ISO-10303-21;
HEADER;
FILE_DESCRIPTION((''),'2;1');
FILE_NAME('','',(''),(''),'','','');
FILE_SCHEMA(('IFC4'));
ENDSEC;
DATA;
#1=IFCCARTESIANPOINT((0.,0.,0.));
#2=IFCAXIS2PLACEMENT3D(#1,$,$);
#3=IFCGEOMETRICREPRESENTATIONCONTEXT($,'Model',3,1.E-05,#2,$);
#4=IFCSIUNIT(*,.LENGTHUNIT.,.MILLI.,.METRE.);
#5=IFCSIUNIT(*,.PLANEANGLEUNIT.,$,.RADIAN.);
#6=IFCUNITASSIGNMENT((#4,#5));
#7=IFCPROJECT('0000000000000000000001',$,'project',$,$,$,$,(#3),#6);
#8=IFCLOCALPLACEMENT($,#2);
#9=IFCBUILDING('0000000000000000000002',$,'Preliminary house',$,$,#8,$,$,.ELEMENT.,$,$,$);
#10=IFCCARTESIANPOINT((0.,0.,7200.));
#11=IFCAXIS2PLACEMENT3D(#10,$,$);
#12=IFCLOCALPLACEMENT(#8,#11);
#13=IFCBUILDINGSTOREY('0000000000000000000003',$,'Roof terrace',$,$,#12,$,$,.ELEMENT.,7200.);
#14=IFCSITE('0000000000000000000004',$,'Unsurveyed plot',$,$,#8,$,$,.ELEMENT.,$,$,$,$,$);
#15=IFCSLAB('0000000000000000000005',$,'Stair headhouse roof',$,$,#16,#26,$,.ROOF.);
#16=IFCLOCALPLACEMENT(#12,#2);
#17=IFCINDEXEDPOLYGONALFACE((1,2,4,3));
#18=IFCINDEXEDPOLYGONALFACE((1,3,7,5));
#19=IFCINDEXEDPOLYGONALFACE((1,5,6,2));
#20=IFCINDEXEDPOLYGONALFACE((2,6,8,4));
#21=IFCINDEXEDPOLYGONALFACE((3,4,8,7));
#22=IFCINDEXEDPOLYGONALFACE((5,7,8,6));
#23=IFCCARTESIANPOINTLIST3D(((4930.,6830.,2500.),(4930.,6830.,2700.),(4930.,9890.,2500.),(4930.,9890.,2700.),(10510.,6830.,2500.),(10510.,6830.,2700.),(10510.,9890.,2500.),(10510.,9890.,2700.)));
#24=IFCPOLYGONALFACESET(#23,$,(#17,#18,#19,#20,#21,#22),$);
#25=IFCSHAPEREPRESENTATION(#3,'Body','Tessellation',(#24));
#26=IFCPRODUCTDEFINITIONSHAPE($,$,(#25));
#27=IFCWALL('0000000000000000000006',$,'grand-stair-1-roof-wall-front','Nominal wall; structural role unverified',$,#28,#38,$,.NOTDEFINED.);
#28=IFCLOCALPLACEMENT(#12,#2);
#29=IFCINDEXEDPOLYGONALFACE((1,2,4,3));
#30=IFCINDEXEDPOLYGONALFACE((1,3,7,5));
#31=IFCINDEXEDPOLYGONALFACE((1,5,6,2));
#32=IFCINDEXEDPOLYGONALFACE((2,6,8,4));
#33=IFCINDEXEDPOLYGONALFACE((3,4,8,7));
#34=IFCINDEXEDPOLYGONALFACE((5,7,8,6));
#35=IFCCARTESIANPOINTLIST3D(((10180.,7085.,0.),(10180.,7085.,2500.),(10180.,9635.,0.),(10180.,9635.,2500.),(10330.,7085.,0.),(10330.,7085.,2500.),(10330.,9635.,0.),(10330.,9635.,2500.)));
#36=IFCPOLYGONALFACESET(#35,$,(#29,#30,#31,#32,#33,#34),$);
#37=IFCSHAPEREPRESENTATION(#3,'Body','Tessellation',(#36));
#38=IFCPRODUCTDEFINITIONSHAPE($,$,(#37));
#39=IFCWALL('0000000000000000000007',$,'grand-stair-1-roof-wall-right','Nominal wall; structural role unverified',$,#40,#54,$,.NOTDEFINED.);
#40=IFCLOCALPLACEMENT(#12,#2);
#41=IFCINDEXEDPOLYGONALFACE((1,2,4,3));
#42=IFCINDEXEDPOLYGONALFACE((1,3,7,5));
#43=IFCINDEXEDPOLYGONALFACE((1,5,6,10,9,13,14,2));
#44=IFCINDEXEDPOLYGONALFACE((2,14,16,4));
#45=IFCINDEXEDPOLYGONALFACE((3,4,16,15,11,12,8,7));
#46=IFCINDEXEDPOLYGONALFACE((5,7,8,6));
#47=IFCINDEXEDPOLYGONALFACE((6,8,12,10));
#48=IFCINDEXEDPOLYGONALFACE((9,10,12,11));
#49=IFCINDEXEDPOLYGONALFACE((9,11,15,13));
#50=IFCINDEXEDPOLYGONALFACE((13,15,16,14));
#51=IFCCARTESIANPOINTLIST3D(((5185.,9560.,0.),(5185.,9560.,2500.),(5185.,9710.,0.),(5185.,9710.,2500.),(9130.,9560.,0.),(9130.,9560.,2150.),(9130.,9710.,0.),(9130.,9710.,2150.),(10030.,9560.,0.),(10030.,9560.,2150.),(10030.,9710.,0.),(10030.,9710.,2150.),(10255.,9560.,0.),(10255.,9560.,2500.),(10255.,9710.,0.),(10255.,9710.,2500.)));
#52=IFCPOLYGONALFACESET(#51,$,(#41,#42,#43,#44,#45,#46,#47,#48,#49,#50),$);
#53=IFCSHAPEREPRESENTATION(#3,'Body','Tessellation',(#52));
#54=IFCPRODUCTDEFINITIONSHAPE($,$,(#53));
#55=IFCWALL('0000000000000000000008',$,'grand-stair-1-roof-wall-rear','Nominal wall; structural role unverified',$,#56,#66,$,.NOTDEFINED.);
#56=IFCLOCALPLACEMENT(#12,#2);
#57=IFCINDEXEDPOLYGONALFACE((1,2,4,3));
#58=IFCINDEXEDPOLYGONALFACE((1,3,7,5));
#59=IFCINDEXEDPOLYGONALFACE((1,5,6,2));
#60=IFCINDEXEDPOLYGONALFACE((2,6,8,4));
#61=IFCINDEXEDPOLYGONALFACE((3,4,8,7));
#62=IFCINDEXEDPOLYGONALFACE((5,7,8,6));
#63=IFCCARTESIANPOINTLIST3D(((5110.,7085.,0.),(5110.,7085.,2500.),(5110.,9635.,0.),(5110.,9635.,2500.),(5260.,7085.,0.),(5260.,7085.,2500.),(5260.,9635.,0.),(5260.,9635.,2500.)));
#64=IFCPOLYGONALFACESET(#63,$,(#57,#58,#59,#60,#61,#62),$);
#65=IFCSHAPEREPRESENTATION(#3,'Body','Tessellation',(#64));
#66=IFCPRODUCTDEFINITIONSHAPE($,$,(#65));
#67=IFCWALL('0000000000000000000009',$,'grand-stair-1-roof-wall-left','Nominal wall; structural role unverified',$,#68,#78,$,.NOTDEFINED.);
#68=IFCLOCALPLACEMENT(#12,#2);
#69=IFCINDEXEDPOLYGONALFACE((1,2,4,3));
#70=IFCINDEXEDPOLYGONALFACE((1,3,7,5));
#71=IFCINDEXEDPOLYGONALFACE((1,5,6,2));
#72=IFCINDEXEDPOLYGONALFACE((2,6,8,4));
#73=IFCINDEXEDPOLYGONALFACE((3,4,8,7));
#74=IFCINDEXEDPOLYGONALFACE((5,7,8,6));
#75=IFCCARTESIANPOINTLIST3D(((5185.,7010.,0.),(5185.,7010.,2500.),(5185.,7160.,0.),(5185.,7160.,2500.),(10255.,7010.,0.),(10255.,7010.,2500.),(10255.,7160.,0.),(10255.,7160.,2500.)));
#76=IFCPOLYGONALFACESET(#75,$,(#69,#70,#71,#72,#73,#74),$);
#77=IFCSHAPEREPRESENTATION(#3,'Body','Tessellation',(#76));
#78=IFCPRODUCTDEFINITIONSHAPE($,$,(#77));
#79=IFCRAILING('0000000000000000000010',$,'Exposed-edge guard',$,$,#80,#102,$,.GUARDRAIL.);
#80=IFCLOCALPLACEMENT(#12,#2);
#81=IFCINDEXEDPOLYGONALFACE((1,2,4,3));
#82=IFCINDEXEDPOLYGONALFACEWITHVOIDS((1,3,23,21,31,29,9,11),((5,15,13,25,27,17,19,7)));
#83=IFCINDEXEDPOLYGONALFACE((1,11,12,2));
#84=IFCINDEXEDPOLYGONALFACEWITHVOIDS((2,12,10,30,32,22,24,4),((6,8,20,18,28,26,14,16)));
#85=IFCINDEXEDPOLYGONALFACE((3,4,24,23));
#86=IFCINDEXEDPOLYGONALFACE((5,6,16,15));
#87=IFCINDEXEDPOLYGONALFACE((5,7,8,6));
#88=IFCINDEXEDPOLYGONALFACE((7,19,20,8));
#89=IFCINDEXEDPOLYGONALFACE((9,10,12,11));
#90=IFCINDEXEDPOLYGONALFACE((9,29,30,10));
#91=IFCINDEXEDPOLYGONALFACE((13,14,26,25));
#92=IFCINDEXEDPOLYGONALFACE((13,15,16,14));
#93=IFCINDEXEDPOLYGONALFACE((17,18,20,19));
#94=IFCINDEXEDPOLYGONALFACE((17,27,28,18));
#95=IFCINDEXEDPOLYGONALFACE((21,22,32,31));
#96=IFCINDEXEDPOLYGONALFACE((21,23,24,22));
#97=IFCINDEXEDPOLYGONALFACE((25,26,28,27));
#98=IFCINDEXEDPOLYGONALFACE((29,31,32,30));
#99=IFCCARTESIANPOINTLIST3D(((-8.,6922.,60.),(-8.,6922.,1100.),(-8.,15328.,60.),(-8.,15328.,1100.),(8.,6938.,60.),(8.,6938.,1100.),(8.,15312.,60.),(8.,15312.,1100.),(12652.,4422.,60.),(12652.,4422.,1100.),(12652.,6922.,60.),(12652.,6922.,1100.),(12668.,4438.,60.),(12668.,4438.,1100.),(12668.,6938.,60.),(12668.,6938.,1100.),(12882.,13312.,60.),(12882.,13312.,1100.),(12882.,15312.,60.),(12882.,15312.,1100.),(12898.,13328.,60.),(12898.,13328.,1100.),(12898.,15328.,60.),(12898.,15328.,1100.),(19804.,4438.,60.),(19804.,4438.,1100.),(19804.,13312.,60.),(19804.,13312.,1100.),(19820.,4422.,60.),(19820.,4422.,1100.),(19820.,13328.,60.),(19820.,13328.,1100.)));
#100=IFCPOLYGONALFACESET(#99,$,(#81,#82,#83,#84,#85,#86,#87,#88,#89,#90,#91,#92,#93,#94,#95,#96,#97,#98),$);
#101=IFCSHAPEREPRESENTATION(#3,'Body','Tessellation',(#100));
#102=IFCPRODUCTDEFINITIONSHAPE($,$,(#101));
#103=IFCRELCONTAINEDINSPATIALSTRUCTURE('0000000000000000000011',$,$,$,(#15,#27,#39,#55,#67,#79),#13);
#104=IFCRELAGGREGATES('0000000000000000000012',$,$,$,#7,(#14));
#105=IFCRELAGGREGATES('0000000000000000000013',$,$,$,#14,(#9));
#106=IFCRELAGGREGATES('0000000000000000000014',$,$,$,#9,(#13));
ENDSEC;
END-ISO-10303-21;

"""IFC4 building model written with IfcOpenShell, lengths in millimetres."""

from ifc_helpers import new_model, si_unit, frame, origin, place, context, project, spatial, polyline, outline, extrude, element, save


model = new_model("IFC4")

# Units and contexts
model_context = context("Model", 3, precision=1e-05, world=origin())
ifc_project = project(units=[si_unit("LENGTHUNIT", "METRE", prefix="MILLI"), si_unit("PLANEANGLEUNIT", "RADIAN")], contexts=[model_context])

# Site, building, storey
placement_1 = place(None, origin())
site = spatial("IfcSite", under=ifc_project, at=placement_1, Name="Unsurveyed plot", CompositionType="ELEMENT")
building = spatial("IfcBuilding", under=site, at=placement_1, Name="Preliminary house", CompositionType="ELEMENT")
placement_2 = place(placement_1, frame((0.0, 0.0, 7200.0)))
storey = spatial("IfcBuildingStorey", under=building, at=placement_2, Name="Roof terrace", CompositionType="ELEMENT", Elevation=7200.0)

# Slab
element("IfcSlab", 1, at=placement_2, inside=storey, Name="Stair headhouse roof", PredefinedType="ROOF", context=model_context, shape_type="SweptSolid", body=[
    extrude(outline(polyline([(10510.0, 6830.0), (4930.0, 6830.0), (4930.0, 9890.0), (10510.0, 9890.0), (10510.0, 6830.0)])), frame((0.0, 0.0, 2500.0)), (0.0, 0.0, 1.0), 200.0),
])

# Wall
element("IfcWall", 2, at=placement_2, inside=storey, Name="grand-stair-1-roof-wall-front", Description="Nominal wall; structural role unverified", PredefinedType="NOTDEFINED", context=model_context, shape_type="SweptSolid", body=[
    extrude(outline(polyline([(10180.0, 9635.0), (10330.0, 9635.0), (10330.0, 7085.0), (10180.0, 7085.0), (10180.0, 9635.0)])), origin(), (0.0, 0.0, 1.0), 2500.0),
])

# Wall, opening
wall_1 = element("IfcWall", 3, at=placement_2, inside=storey, Name="grand-stair-1-roof-wall-right", Description="Nominal wall; structural role unverified", PredefinedType="NOTDEFINED", context=model_context, shape_type="SweptSolid", body=[
    extrude(outline(polyline([(5185.0, 9560.0), (5185.0, 9710.0), (10255.0, 9710.0), (10255.0, 9560.0), (5185.0, 9560.0)])), origin(), (0.0, 0.0, 1.0), 2500.0),
])
element("IfcOpeningElement", 4, at=placement_2, cuts=wall_1, PredefinedType="OPENING", context=model_context, shape_type="SweptSolid", body=[
    extrude(outline(polyline([(10030.0, 10085.0), (9130.0, 10085.0), (9130.0, 9185.0), (10030.0, 9185.0), (10030.0, 10085.0)])), origin(), (0.0, 0.0, 1.0), 2150.0),
])

# Walls
element("IfcWall", 5, at=placement_2, inside=storey, Name="grand-stair-1-roof-wall-rear", Description="Nominal wall; structural role unverified", PredefinedType="NOTDEFINED", context=model_context, shape_type="SweptSolid", body=[
    extrude(outline(polyline([(5110.0, 9635.0), (5260.0, 9635.0), (5260.0, 7085.0), (5110.0, 7085.0), (5110.0, 9635.0)])), origin(), (0.0, 0.0, 1.0), 2500.0),
])
element("IfcWall", 6, at=placement_2, inside=storey, Name="grand-stair-1-roof-wall-left", Description="Nominal wall; structural role unverified", PredefinedType="NOTDEFINED", context=model_context, shape_type="SweptSolid", body=[
    extrude(outline(polyline([(5185.0, 7010.0), (5185.0, 7160.0), (10255.0, 7160.0), (10255.0, 7010.0), (5185.0, 7010.0)])), origin(), (0.0, 0.0, 1.0), 2500.0),
])

# Railing
element("IfcRailing", 7, at=placement_2, inside=storey, Name="Exposed-edge guard", PredefinedType="GUARDRAIL", context=model_context, shape_type="SweptSolid", body=[
    extrude(outline(polyline([(-8.0, 15328.0), (12898.0, 15328.0), (12898.0, 13328.0), (19820.0, 13328.0), (19820.0, 4422.0), (12652.0, 4422.0), (12652.0, 6922.0), (-8.0, 6922.0), (-8.0, 15328.0)]), holes=[polyline([(8.0, 15312.0), (8.0, 6938.0), (12668.0, 6938.0), (12668.0, 4438.0), (19804.0, 4438.0), (19804.0, 13312.0), (12882.0, 13312.0), (12882.0, 15312.0), (8.0, 15312.0)])]), frame((0.0, 0.0, 60.0)), (0.0, 0.0, 1.0), 1040.0),
])

save(model, "model.ifc")
